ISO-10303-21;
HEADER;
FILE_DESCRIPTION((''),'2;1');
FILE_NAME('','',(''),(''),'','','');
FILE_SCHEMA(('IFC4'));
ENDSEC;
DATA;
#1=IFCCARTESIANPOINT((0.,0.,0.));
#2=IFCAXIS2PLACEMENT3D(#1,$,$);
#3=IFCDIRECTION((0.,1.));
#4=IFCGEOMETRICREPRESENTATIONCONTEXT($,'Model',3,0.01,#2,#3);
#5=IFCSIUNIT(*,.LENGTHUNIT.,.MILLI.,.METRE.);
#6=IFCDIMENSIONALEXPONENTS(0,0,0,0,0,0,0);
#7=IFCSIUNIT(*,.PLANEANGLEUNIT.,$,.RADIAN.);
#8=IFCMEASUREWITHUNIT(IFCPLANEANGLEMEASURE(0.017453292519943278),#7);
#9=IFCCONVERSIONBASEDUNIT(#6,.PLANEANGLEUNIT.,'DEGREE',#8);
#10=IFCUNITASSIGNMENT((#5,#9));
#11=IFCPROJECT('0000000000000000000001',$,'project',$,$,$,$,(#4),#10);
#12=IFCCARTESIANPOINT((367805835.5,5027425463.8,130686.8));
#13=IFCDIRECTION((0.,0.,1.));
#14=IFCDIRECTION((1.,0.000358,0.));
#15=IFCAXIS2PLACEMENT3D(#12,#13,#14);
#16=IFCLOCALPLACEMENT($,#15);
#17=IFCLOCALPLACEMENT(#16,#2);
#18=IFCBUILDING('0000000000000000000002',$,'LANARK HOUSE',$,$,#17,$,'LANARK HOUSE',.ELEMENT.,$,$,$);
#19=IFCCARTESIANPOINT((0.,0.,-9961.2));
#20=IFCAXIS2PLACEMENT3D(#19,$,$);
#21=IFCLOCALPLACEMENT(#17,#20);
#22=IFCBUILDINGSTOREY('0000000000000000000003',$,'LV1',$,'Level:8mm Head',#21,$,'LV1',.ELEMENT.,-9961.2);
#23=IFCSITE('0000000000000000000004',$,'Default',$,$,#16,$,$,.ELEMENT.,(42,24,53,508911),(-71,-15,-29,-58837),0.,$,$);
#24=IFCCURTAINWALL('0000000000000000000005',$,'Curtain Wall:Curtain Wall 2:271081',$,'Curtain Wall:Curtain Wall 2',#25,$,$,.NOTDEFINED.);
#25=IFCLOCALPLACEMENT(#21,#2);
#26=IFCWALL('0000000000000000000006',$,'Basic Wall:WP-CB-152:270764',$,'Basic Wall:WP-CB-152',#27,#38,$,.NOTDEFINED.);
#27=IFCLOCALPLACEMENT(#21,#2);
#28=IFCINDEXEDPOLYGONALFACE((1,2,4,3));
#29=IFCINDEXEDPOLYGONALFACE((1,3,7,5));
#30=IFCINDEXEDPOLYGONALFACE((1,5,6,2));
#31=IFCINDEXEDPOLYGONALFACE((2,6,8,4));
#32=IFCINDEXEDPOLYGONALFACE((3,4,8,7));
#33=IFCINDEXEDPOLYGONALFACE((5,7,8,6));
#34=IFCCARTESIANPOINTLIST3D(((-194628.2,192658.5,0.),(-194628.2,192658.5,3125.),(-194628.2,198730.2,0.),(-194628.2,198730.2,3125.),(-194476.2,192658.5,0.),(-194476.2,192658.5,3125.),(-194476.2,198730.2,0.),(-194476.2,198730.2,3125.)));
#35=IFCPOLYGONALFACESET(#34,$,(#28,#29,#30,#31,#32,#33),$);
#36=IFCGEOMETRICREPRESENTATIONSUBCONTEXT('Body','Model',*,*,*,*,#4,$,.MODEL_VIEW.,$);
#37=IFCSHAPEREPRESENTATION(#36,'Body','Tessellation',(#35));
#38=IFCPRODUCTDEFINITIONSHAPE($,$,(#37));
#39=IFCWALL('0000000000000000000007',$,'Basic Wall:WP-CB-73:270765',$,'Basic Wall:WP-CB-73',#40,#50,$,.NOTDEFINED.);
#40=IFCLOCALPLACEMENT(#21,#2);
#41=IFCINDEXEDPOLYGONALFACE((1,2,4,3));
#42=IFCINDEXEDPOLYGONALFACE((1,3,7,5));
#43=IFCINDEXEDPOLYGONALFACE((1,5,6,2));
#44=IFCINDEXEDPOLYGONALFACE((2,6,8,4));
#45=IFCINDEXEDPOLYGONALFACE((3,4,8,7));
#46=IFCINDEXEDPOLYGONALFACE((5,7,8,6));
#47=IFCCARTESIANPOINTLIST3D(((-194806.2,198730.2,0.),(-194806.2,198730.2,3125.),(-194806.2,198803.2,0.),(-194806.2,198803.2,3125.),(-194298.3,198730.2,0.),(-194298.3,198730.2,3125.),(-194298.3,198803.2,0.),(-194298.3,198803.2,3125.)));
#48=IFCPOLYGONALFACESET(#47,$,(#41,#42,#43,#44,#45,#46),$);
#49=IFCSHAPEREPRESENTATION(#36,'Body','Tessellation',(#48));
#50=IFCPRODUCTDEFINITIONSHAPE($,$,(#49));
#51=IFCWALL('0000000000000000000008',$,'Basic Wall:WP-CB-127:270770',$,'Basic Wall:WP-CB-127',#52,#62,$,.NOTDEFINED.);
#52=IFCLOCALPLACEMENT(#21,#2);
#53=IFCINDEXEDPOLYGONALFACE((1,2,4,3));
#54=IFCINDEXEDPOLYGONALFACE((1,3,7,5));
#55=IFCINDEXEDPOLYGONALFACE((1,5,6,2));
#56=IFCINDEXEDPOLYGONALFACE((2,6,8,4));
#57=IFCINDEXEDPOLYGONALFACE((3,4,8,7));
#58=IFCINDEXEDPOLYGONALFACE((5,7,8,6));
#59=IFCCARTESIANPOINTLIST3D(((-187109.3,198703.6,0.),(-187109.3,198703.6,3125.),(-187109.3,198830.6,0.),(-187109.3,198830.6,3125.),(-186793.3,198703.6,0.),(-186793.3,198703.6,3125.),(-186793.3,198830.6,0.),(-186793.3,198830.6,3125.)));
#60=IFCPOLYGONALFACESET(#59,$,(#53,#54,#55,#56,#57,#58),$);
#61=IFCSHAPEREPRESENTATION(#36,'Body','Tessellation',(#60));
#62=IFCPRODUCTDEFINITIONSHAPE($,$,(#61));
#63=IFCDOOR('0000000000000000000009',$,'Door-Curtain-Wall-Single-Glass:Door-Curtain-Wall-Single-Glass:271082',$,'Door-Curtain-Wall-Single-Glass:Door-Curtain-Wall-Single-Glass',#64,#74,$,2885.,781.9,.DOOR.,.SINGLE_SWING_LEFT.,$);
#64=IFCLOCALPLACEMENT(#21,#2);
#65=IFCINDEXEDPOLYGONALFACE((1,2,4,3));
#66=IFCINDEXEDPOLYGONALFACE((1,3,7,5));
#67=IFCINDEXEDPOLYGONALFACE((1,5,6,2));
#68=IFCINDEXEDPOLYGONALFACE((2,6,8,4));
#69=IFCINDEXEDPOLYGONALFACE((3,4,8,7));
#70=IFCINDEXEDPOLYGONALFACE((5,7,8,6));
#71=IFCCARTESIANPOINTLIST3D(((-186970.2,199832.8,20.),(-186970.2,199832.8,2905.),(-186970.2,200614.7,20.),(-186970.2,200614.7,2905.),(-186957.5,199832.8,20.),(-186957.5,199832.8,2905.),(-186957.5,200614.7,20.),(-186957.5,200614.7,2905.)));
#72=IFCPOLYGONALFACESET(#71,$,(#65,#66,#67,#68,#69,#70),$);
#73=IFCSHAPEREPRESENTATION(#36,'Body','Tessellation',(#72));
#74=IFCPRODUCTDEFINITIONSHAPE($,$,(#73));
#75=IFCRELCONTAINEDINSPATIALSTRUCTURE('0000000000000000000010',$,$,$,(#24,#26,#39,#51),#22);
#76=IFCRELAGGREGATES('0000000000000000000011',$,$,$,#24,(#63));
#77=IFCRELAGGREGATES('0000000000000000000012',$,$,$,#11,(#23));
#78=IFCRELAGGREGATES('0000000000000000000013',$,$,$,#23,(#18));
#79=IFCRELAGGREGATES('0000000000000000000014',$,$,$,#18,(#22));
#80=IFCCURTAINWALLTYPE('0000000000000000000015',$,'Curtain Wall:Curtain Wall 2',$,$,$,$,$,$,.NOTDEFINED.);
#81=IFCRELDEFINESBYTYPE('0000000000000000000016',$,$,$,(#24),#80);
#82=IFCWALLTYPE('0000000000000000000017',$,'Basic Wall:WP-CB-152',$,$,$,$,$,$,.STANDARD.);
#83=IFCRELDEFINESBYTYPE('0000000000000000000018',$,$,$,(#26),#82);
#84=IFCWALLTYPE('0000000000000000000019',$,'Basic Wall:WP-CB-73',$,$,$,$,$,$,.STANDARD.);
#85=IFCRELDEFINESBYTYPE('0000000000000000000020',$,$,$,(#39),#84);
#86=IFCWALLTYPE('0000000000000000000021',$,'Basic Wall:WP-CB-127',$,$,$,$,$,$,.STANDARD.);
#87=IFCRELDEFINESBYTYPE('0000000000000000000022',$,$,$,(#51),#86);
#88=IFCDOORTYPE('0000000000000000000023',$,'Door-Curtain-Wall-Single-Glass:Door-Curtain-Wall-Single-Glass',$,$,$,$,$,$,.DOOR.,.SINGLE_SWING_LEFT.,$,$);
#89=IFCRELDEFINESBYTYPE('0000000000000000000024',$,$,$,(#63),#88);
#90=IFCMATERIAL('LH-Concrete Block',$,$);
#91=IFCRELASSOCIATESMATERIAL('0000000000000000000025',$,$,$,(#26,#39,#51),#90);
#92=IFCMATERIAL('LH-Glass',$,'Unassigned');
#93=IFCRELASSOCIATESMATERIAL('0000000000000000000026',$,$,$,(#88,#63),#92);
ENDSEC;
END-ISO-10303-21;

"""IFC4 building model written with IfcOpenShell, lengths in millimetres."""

from ifc_helpers import new_model, entity, si_unit, converted_unit, direction, frame, origin, place, context, subcontext, project, spatial, indexed_curve, outline, extrude, source, transform, mapped, material, type_object, type_shapes, element, aggregate, save


model = new_model("IFC4")

# Units and contexts
model_context = context("Model", 3, precision=0.01, world=origin(), true_north=direction((0.0, 1.0)))
body_context = subcontext(model_context, "Body", "Model", "MODEL_VIEW")
ifc_project = project(units=[si_unit("LENGTHUNIT", "METRE", prefix="MILLI"), converted_unit("PLANEANGLEUNIT", "DEGREE", entity("IfcPlaneAngleMeasure", 0.017453292519943278), si_unit("PLANEANGLEUNIT", "RADIAN"), dimensions=[0, 0, 0, 0, 0, 0, 0])], contexts=[model_context])

# Site, building, storey
site_placement = place(None, frame((367805835.5, 5027425463.8, 130686.8), z_axis=(0.0, 0.0, 1.0), x_axis=(1.0, 0.000358, 0.0)))
site = spatial("IfcSite", under=ifc_project, at=site_placement, Name="Default", CompositionType="ELEMENT", RefLatitude=(42, 24, 53, 508911), RefLongitude=(-71, -15, -29, -58837), RefElevation=0.0)
building_placement = place(site_placement, origin())
building = spatial("IfcBuilding", under=site, at=building_placement, Name="LANARK HOUSE", LongName="LANARK HOUSE", CompositionType="ELEMENT")
storey_placement = place(building_placement, frame((0.0, 0.0, -9961.2)))
storey = spatial("IfcBuildingStorey", under=building, at=storey_placement, Name="LV1", ObjectType="Level:8mm Head", LongName="LV1", CompositionType="ELEMENT", Elevation=-9961.2)

# Curtain wall
curtain_wall_type = type_object("IfcCurtainWallType", Name="Curtain Wall:Curtain Wall 2", PredefinedType="NOTDEFINED")
curtain_wall_placement = place(storey_placement, frame((0.0, 0.0, 9961.2)))
curtain_wall = element("IfcCurtainWall", 1, at=curtain_wall_placement, inside=storey, type_object=curtain_wall_type, Name="Curtain Wall:Curtain Wall 2:271081", ObjectType="Curtain Wall:Curtain Wall 2", PredefinedType="NOTDEFINED")

# Shared definitions
ifc_material_1 = material(Name="LH-Glass", Category="Unassigned")

# Walls
ifc_material_2 = material(Name="LH-Concrete Block")
wall_type_1 = type_object("IfcWallType", Name="Basic Wall:WP-CB-152", PredefinedType="STANDARD")
wall_1_placement = place(storey_placement, frame((-194552.2, 198730.2, 0.0), z_axis=(0.0, 0.0, 1.0), x_axis=(0.0, -1.0, 0.0)))
element("IfcWall", 2, at=wall_1_placement, inside=storey, type_object=wall_type_1, material=ifc_material_2, Name="Basic Wall:WP-CB-152:270764", ObjectType="Basic Wall:WP-CB-152", PredefinedType="NOTDEFINED", context=body_context, shape_type="SweptSolid", body=[
    extrude(outline(indexed_curve([(6071.8, 76.0), (0.0, 76.0), (0.0, -76.0), (6071.8, -76.0), (6071.8, 76.0)], self_intersect=False)), origin(), (0.0, 0.0, 1.0), 3125.0),
])
wall_type_2 = type_object("IfcWallType", Name="Basic Wall:WP-CB-73", PredefinedType="STANDARD")
wall_2_placement = place(storey_placement, frame((-194298.3, 198766.7, 0.0), z_axis=(0.0, 0.0, 1.0), x_axis=(-1.0, 0.0, 0.0)))
element("IfcWall", 3, at=wall_2_placement, inside=storey, type_object=wall_type_2, material=ifc_material_2, Name="Basic Wall:WP-CB-73:270765", ObjectType="Basic Wall:WP-CB-73", PredefinedType="NOTDEFINED", context=body_context, shape_type="SweptSolid", body=[
    extrude(outline(indexed_curve([(507.9, 36.5), (0.0, 36.5), (0.0, -36.5), (507.9, -36.5), (507.9, 36.5)], self_intersect=False)), origin(), (0.0, 0.0, 1.0), 3125.0),
])
wall_type_3 = type_object("IfcWallType", Name="Basic Wall:WP-CB-127", PredefinedType="STANDARD")
wall_3_placement = place(storey_placement, frame((-187109.3, 198767.1, 0.0)))
element("IfcWall", 4, at=wall_3_placement, inside=storey, type_object=wall_type_3, material=ifc_material_2, Name="Basic Wall:WP-CB-127:270770", ObjectType="Basic Wall:WP-CB-127", PredefinedType="NOTDEFINED", context=body_context, shape_type="SweptSolid", body=[
    extrude(outline(indexed_curve([(316.0, 63.5), (0.0, 63.5), (0.0, -63.5), (316.0, -63.5), (316.0, 63.5)], self_intersect=False)), origin(), (0.0, 0.0, 1.0), 3125.0),
])

# Door
door_type_1 = type_object("IfcDoorType", Name="Door-Curtain-Wall-Single-Glass:Door-Curtain-Wall-Single-Glass", OperationType="SINGLE_SWING_LEFT", PredefinedType="DOOR", material=ifc_material_1)
shared_shape_1 = source(origin(), body_context, "Body", "SweptSolid", [
    extrude(outline(indexed_curve([(-6.4, -390.9), (6.4, -390.9), (6.4, 390.9), (-6.4, 390.9), (-6.4, -390.9)], self_intersect=False)), frame((0.0, 44.5, 0.0), z_axis=(0.0, 0.0, 1.0), x_axis=(0.0, -1.0, 0.0)), (0.0, 0.0, 1.0), 2885.0),
])
type_shapes(door_type_1, [shared_shape_1])
door_1_placement = place(curtain_wall_placement, frame((-187008.3, 200223.8, -9941.2), z_axis=(0.0, 0.0, 1.0), x_axis=(0.0, -1.0, 0.0)))
door_1 = element("IfcDoor", 5, at=door_1_placement, type_object=door_type_1, material=ifc_material_1, Name="Door-Curtain-Wall-Single-Glass:Door-Curtain-Wall-Single-Glass:271082", ObjectType="Door-Curtain-Wall-Single-Glass:Door-Curtain-Wall-Single-Glass", OperationType="SINGLE_SWING_LEFT", OverallHeight=2885.0, OverallWidth=781.9, PredefinedType="DOOR", context=body_context, shape_type="MappedRepresentation", body=[
    mapped(shared_shape_1, transform((0.0, 0.0, 0.0), scale=1.0)),
])
aggregate(curtain_wall, [door_1])

save(model, "model.ifc")
